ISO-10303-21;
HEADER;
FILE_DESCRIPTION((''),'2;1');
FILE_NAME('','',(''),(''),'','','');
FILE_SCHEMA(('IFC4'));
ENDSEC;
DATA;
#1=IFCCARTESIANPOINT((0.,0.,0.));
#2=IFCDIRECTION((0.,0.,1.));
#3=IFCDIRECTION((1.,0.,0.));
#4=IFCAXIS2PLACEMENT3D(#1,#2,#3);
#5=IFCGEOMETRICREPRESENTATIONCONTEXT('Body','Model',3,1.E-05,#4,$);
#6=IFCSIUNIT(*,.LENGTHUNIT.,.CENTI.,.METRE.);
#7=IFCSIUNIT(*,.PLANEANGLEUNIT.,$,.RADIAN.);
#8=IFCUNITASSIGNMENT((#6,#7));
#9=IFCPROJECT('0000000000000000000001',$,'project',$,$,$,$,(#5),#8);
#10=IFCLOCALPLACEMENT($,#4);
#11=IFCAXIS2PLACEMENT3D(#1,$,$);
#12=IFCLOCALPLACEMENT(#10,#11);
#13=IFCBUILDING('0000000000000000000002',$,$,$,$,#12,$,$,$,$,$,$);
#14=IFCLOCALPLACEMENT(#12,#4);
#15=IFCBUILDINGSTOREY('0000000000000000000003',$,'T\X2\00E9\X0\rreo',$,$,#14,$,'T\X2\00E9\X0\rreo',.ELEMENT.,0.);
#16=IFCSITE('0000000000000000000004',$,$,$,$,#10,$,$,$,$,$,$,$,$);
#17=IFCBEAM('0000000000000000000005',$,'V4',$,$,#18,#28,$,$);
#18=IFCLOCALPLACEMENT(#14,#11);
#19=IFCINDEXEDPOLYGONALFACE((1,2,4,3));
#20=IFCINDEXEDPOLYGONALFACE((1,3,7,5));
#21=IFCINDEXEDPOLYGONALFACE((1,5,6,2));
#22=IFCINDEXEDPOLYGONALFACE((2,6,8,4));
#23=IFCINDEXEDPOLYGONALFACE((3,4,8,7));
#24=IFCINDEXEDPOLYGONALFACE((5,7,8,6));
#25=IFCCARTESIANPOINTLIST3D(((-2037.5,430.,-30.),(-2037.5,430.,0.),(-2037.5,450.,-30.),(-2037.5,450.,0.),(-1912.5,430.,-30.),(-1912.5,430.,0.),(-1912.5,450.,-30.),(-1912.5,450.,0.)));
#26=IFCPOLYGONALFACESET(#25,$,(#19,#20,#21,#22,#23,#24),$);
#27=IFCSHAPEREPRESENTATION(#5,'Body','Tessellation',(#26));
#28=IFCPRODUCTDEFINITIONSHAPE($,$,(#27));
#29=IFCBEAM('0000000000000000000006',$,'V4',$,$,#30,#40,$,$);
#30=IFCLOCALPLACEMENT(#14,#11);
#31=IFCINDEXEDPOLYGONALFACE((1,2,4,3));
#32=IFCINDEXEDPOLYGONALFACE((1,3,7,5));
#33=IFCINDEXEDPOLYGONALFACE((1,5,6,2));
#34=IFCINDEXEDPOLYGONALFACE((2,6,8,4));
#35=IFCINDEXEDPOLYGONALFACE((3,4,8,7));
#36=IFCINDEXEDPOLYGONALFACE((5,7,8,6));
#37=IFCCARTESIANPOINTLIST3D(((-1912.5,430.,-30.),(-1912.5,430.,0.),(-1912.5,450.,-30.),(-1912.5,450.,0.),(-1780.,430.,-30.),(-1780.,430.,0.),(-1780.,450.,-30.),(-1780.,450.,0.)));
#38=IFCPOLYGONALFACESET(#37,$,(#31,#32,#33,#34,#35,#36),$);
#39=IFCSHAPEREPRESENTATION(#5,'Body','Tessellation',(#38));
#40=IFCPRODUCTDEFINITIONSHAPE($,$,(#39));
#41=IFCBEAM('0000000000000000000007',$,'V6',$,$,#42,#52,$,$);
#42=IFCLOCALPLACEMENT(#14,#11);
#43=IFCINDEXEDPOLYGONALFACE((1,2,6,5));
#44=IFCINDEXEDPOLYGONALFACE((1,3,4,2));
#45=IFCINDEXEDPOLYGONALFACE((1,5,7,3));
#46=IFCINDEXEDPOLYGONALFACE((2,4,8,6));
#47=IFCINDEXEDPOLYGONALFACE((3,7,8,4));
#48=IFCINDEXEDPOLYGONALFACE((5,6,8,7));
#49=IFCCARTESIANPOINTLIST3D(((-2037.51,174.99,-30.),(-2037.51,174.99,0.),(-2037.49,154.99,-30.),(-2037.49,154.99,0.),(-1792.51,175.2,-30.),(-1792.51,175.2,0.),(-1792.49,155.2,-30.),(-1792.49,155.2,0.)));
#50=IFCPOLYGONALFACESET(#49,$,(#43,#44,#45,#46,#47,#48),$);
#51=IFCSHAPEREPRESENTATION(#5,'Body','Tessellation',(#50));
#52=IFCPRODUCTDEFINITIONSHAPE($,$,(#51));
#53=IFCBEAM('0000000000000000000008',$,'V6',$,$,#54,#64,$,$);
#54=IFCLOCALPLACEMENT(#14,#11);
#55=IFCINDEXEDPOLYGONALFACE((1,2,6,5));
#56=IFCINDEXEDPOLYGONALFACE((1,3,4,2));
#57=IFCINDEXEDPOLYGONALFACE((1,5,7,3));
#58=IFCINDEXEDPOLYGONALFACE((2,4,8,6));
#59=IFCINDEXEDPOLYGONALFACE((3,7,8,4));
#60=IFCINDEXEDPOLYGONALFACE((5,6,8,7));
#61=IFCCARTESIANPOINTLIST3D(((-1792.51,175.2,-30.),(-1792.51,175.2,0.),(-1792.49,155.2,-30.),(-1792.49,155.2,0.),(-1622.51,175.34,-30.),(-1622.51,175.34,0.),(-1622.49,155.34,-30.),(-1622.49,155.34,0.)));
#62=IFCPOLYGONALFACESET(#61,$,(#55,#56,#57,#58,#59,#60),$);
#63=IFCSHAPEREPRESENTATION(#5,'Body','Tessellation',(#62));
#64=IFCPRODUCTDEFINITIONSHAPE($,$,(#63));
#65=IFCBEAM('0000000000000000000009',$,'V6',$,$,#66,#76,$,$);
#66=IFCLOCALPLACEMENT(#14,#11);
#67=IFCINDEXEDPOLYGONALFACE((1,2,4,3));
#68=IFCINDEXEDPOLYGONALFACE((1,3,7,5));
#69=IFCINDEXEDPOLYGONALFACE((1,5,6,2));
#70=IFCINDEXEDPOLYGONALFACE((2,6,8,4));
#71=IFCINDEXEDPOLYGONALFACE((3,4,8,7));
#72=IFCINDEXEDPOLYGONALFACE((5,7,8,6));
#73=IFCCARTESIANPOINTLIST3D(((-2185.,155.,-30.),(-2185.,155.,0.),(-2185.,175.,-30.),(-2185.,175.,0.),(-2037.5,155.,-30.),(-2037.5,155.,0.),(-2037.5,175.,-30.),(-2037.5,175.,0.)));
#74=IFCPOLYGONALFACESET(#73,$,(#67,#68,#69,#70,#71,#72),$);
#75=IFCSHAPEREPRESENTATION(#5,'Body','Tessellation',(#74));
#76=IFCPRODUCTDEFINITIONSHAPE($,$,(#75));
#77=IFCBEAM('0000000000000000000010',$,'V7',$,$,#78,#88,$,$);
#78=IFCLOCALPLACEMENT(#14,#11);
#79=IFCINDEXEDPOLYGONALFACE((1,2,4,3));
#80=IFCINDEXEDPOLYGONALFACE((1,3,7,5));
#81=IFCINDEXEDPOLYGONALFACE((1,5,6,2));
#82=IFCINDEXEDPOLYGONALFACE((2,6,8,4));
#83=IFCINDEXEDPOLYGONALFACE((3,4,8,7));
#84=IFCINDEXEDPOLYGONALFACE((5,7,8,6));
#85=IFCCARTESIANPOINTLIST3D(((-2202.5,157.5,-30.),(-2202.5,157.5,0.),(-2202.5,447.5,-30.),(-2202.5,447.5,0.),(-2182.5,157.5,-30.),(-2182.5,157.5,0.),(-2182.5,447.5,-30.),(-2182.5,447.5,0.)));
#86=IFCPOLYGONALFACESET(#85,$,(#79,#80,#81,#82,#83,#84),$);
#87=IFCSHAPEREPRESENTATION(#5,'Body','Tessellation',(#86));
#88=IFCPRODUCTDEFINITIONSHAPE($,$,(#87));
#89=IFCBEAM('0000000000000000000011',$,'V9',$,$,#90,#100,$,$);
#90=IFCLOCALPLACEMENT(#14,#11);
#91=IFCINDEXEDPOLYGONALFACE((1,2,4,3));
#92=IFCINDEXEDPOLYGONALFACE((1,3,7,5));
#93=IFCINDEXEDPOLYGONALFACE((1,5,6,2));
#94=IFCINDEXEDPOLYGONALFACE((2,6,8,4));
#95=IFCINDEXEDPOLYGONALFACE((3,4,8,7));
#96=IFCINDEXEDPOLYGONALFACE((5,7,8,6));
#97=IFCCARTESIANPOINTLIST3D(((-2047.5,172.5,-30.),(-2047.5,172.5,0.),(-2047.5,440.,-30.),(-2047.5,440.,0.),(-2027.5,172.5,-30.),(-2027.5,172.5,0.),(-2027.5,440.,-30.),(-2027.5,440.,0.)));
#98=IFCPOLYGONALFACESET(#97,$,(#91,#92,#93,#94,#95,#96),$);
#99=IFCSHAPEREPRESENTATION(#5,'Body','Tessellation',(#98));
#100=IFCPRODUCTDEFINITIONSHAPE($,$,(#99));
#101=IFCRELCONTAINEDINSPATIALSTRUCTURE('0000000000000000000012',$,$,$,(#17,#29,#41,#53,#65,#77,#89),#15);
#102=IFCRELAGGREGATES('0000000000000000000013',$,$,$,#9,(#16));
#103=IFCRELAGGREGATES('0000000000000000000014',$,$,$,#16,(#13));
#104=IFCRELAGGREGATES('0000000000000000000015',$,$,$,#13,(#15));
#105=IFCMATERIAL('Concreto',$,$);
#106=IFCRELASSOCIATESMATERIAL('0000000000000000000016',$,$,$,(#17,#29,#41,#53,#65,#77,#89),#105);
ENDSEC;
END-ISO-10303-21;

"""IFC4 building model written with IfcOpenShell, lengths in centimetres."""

from ifc_helpers import new_model, si_unit, frame, origin, origin_with_axes, origin_2d_with_axis, place, context, project, spatial, rectangle, extrude, material, element, save


model = new_model("IFC4")

# Units and contexts
model_context = context("Model", 3, precision=1e-05, world=origin_with_axes(), identifier="Body")
ifc_project = project(units=[si_unit("LENGTHUNIT", "METRE", prefix="CENTI"), si_unit("PLANEANGLEUNIT", "RADIAN")], contexts=[model_context])

# Site, building, storey
site_placement = place(None, origin_with_axes())
site = spatial("IfcSite", under=ifc_project, at=site_placement)
building_placement = place(site_placement, origin())
building = spatial("IfcBuilding", under=site, at=building_placement)
storey_placement = place(building_placement, origin_with_axes())
storey = spatial("IfcBuildingStorey", under=building, at=storey_placement, Name="Térreo", LongName="Térreo", CompositionType="ELEMENT", Elevation=0.0)

# Shared definitions
ifc_material = material(Name="Concreto")

# Beams
beam_1_placement = place(storey_placement, frame((-1975.0, 440.0, 0.0), z_axis=(0.0, 0.0, 1.0), x_axis=(1.0, 0.0, 0.0)))
element("IfcBeam", 1, at=beam_1_placement, inside=storey, material=ifc_material, Name="V4", context=model_context, shape_type="SolidModel", body=[
    extrude(rectangle(XDim=20.0, YDim=30.0, at=origin_2d_with_axis()), frame((-62.5, 0.0, -15.0), z_axis=(1.0, 0.0, 0.0), x_axis=(0.0, -1.0, 0.0)), (0.0, 0.0, 1.0), 125.0),
])
beam_2_placement = place(storey_placement, frame((-1846.25, 440.0, 0.0), z_axis=(0.0, 0.0, 1.0), x_axis=(1.0, 0.0, 0.0)))
element("IfcBeam", 2, at=beam_2_placement, inside=storey, material=ifc_material, Name="V4", context=model_context, shape_type="SolidModel", body=[
    extrude(rectangle(XDim=20.0, YDim=30.0, at=origin_2d_with_axis()), frame((-66.25, 0.0, -15.0), z_axis=(1.0, 0.0, 0.0), x_axis=(0.0, -1.0, 0.0)), (0.0, 0.0, 1.0), 132.5),
])
beam_3_placement = place(storey_placement, frame((-1915.0, 165.09, 0.0), z_axis=(0.0, 0.0, 1.0), x_axis=(1.0, 0.0, 0.0)))
element("IfcBeam", 3, at=beam_3_placement, inside=storey, material=ifc_material, Name="V6", context=model_context, shape_type="SolidModel", body=[
    extrude(rectangle(XDim=20.0, YDim=30.0, at=origin_2d_with_axis()), frame((-122.5, -0.11, -15.0), z_axis=(1.0, 0.000864, 0.0), x_axis=(0.000864, -1.0, 0.0)), (0.0, 0.0, 1.0), 245.0),
])
beam_4_placement = place(storey_placement, frame((-1707.5, 165.27, 0.0), z_axis=(0.0, 0.0, 1.0), x_axis=(1.0, 0.0, 0.0)))
element("IfcBeam", 4, at=beam_4_placement, inside=storey, material=ifc_material, Name="V6", context=model_context, shape_type="SolidModel", body=[
    extrude(rectangle(XDim=20.0, YDim=30.0, at=origin_2d_with_axis()), frame((-85.0, -0.07, -15.0), z_axis=(1.0, 0.000828, 0.0), x_axis=(0.000828, -1.0, 0.0)), (0.0, 0.0, 1.0), 170.0),
])
beam_5_placement = place(storey_placement, frame((-2111.25, 165.0, 0.0), z_axis=(0.0, 0.0, 1.0), x_axis=(1.0, 0.0, 0.0)))
element("IfcBeam", 5, at=beam_5_placement, inside=storey, material=ifc_material, Name="V6", context=model_context, shape_type="SolidModel", body=[
    extrude(rectangle(XDim=20.0, YDim=30.0, at=origin_2d_with_axis()), frame((-73.75, 0.0, -15.0), z_axis=(1.0, 0.0, 0.0), x_axis=(0.0, -1.0, 0.0)), (0.0, 0.0, 1.0), 147.5),
])
beam_6_placement = place(storey_placement, frame((-2192.5, 302.5, 0.0), z_axis=(0.0, 0.0, 1.0), x_axis=(1.0, 0.0, 0.0)))
element("IfcBeam", 6, at=beam_6_placement, inside=storey, material=ifc_material, Name="V7", context=model_context, shape_type="SolidModel", body=[
    extrude(rectangle(XDim=20.0, YDim=30.0, at=origin_2d_with_axis()), frame((0.0, -145.0, -15.0), z_axis=(0.0, 1.0, 0.0), x_axis=(-1.0, 0.0, 0.0)), (0.0, 0.0, 1.0), 290.0),
])
beam_7_placement = place(storey_placement, frame((-2037.5, 306.25, 0.0), z_axis=(0.0, 0.0, 1.0), x_axis=(1.0, 0.0, 0.0)))
element("IfcBeam", 7, at=beam_7_placement, inside=storey, material=ifc_material, Name="V9", context=model_context, shape_type="SolidModel", body=[
    extrude(rectangle(XDim=20.0, YDim=30.0, at=origin_2d_with_axis()), frame((0.0, -133.75, -15.0), z_axis=(0.0, 1.0, 0.0), x_axis=(-1.0, 0.0, 0.0)), (0.0, 0.0, 1.0), 267.5),
])

save(model, "model.ifc")
